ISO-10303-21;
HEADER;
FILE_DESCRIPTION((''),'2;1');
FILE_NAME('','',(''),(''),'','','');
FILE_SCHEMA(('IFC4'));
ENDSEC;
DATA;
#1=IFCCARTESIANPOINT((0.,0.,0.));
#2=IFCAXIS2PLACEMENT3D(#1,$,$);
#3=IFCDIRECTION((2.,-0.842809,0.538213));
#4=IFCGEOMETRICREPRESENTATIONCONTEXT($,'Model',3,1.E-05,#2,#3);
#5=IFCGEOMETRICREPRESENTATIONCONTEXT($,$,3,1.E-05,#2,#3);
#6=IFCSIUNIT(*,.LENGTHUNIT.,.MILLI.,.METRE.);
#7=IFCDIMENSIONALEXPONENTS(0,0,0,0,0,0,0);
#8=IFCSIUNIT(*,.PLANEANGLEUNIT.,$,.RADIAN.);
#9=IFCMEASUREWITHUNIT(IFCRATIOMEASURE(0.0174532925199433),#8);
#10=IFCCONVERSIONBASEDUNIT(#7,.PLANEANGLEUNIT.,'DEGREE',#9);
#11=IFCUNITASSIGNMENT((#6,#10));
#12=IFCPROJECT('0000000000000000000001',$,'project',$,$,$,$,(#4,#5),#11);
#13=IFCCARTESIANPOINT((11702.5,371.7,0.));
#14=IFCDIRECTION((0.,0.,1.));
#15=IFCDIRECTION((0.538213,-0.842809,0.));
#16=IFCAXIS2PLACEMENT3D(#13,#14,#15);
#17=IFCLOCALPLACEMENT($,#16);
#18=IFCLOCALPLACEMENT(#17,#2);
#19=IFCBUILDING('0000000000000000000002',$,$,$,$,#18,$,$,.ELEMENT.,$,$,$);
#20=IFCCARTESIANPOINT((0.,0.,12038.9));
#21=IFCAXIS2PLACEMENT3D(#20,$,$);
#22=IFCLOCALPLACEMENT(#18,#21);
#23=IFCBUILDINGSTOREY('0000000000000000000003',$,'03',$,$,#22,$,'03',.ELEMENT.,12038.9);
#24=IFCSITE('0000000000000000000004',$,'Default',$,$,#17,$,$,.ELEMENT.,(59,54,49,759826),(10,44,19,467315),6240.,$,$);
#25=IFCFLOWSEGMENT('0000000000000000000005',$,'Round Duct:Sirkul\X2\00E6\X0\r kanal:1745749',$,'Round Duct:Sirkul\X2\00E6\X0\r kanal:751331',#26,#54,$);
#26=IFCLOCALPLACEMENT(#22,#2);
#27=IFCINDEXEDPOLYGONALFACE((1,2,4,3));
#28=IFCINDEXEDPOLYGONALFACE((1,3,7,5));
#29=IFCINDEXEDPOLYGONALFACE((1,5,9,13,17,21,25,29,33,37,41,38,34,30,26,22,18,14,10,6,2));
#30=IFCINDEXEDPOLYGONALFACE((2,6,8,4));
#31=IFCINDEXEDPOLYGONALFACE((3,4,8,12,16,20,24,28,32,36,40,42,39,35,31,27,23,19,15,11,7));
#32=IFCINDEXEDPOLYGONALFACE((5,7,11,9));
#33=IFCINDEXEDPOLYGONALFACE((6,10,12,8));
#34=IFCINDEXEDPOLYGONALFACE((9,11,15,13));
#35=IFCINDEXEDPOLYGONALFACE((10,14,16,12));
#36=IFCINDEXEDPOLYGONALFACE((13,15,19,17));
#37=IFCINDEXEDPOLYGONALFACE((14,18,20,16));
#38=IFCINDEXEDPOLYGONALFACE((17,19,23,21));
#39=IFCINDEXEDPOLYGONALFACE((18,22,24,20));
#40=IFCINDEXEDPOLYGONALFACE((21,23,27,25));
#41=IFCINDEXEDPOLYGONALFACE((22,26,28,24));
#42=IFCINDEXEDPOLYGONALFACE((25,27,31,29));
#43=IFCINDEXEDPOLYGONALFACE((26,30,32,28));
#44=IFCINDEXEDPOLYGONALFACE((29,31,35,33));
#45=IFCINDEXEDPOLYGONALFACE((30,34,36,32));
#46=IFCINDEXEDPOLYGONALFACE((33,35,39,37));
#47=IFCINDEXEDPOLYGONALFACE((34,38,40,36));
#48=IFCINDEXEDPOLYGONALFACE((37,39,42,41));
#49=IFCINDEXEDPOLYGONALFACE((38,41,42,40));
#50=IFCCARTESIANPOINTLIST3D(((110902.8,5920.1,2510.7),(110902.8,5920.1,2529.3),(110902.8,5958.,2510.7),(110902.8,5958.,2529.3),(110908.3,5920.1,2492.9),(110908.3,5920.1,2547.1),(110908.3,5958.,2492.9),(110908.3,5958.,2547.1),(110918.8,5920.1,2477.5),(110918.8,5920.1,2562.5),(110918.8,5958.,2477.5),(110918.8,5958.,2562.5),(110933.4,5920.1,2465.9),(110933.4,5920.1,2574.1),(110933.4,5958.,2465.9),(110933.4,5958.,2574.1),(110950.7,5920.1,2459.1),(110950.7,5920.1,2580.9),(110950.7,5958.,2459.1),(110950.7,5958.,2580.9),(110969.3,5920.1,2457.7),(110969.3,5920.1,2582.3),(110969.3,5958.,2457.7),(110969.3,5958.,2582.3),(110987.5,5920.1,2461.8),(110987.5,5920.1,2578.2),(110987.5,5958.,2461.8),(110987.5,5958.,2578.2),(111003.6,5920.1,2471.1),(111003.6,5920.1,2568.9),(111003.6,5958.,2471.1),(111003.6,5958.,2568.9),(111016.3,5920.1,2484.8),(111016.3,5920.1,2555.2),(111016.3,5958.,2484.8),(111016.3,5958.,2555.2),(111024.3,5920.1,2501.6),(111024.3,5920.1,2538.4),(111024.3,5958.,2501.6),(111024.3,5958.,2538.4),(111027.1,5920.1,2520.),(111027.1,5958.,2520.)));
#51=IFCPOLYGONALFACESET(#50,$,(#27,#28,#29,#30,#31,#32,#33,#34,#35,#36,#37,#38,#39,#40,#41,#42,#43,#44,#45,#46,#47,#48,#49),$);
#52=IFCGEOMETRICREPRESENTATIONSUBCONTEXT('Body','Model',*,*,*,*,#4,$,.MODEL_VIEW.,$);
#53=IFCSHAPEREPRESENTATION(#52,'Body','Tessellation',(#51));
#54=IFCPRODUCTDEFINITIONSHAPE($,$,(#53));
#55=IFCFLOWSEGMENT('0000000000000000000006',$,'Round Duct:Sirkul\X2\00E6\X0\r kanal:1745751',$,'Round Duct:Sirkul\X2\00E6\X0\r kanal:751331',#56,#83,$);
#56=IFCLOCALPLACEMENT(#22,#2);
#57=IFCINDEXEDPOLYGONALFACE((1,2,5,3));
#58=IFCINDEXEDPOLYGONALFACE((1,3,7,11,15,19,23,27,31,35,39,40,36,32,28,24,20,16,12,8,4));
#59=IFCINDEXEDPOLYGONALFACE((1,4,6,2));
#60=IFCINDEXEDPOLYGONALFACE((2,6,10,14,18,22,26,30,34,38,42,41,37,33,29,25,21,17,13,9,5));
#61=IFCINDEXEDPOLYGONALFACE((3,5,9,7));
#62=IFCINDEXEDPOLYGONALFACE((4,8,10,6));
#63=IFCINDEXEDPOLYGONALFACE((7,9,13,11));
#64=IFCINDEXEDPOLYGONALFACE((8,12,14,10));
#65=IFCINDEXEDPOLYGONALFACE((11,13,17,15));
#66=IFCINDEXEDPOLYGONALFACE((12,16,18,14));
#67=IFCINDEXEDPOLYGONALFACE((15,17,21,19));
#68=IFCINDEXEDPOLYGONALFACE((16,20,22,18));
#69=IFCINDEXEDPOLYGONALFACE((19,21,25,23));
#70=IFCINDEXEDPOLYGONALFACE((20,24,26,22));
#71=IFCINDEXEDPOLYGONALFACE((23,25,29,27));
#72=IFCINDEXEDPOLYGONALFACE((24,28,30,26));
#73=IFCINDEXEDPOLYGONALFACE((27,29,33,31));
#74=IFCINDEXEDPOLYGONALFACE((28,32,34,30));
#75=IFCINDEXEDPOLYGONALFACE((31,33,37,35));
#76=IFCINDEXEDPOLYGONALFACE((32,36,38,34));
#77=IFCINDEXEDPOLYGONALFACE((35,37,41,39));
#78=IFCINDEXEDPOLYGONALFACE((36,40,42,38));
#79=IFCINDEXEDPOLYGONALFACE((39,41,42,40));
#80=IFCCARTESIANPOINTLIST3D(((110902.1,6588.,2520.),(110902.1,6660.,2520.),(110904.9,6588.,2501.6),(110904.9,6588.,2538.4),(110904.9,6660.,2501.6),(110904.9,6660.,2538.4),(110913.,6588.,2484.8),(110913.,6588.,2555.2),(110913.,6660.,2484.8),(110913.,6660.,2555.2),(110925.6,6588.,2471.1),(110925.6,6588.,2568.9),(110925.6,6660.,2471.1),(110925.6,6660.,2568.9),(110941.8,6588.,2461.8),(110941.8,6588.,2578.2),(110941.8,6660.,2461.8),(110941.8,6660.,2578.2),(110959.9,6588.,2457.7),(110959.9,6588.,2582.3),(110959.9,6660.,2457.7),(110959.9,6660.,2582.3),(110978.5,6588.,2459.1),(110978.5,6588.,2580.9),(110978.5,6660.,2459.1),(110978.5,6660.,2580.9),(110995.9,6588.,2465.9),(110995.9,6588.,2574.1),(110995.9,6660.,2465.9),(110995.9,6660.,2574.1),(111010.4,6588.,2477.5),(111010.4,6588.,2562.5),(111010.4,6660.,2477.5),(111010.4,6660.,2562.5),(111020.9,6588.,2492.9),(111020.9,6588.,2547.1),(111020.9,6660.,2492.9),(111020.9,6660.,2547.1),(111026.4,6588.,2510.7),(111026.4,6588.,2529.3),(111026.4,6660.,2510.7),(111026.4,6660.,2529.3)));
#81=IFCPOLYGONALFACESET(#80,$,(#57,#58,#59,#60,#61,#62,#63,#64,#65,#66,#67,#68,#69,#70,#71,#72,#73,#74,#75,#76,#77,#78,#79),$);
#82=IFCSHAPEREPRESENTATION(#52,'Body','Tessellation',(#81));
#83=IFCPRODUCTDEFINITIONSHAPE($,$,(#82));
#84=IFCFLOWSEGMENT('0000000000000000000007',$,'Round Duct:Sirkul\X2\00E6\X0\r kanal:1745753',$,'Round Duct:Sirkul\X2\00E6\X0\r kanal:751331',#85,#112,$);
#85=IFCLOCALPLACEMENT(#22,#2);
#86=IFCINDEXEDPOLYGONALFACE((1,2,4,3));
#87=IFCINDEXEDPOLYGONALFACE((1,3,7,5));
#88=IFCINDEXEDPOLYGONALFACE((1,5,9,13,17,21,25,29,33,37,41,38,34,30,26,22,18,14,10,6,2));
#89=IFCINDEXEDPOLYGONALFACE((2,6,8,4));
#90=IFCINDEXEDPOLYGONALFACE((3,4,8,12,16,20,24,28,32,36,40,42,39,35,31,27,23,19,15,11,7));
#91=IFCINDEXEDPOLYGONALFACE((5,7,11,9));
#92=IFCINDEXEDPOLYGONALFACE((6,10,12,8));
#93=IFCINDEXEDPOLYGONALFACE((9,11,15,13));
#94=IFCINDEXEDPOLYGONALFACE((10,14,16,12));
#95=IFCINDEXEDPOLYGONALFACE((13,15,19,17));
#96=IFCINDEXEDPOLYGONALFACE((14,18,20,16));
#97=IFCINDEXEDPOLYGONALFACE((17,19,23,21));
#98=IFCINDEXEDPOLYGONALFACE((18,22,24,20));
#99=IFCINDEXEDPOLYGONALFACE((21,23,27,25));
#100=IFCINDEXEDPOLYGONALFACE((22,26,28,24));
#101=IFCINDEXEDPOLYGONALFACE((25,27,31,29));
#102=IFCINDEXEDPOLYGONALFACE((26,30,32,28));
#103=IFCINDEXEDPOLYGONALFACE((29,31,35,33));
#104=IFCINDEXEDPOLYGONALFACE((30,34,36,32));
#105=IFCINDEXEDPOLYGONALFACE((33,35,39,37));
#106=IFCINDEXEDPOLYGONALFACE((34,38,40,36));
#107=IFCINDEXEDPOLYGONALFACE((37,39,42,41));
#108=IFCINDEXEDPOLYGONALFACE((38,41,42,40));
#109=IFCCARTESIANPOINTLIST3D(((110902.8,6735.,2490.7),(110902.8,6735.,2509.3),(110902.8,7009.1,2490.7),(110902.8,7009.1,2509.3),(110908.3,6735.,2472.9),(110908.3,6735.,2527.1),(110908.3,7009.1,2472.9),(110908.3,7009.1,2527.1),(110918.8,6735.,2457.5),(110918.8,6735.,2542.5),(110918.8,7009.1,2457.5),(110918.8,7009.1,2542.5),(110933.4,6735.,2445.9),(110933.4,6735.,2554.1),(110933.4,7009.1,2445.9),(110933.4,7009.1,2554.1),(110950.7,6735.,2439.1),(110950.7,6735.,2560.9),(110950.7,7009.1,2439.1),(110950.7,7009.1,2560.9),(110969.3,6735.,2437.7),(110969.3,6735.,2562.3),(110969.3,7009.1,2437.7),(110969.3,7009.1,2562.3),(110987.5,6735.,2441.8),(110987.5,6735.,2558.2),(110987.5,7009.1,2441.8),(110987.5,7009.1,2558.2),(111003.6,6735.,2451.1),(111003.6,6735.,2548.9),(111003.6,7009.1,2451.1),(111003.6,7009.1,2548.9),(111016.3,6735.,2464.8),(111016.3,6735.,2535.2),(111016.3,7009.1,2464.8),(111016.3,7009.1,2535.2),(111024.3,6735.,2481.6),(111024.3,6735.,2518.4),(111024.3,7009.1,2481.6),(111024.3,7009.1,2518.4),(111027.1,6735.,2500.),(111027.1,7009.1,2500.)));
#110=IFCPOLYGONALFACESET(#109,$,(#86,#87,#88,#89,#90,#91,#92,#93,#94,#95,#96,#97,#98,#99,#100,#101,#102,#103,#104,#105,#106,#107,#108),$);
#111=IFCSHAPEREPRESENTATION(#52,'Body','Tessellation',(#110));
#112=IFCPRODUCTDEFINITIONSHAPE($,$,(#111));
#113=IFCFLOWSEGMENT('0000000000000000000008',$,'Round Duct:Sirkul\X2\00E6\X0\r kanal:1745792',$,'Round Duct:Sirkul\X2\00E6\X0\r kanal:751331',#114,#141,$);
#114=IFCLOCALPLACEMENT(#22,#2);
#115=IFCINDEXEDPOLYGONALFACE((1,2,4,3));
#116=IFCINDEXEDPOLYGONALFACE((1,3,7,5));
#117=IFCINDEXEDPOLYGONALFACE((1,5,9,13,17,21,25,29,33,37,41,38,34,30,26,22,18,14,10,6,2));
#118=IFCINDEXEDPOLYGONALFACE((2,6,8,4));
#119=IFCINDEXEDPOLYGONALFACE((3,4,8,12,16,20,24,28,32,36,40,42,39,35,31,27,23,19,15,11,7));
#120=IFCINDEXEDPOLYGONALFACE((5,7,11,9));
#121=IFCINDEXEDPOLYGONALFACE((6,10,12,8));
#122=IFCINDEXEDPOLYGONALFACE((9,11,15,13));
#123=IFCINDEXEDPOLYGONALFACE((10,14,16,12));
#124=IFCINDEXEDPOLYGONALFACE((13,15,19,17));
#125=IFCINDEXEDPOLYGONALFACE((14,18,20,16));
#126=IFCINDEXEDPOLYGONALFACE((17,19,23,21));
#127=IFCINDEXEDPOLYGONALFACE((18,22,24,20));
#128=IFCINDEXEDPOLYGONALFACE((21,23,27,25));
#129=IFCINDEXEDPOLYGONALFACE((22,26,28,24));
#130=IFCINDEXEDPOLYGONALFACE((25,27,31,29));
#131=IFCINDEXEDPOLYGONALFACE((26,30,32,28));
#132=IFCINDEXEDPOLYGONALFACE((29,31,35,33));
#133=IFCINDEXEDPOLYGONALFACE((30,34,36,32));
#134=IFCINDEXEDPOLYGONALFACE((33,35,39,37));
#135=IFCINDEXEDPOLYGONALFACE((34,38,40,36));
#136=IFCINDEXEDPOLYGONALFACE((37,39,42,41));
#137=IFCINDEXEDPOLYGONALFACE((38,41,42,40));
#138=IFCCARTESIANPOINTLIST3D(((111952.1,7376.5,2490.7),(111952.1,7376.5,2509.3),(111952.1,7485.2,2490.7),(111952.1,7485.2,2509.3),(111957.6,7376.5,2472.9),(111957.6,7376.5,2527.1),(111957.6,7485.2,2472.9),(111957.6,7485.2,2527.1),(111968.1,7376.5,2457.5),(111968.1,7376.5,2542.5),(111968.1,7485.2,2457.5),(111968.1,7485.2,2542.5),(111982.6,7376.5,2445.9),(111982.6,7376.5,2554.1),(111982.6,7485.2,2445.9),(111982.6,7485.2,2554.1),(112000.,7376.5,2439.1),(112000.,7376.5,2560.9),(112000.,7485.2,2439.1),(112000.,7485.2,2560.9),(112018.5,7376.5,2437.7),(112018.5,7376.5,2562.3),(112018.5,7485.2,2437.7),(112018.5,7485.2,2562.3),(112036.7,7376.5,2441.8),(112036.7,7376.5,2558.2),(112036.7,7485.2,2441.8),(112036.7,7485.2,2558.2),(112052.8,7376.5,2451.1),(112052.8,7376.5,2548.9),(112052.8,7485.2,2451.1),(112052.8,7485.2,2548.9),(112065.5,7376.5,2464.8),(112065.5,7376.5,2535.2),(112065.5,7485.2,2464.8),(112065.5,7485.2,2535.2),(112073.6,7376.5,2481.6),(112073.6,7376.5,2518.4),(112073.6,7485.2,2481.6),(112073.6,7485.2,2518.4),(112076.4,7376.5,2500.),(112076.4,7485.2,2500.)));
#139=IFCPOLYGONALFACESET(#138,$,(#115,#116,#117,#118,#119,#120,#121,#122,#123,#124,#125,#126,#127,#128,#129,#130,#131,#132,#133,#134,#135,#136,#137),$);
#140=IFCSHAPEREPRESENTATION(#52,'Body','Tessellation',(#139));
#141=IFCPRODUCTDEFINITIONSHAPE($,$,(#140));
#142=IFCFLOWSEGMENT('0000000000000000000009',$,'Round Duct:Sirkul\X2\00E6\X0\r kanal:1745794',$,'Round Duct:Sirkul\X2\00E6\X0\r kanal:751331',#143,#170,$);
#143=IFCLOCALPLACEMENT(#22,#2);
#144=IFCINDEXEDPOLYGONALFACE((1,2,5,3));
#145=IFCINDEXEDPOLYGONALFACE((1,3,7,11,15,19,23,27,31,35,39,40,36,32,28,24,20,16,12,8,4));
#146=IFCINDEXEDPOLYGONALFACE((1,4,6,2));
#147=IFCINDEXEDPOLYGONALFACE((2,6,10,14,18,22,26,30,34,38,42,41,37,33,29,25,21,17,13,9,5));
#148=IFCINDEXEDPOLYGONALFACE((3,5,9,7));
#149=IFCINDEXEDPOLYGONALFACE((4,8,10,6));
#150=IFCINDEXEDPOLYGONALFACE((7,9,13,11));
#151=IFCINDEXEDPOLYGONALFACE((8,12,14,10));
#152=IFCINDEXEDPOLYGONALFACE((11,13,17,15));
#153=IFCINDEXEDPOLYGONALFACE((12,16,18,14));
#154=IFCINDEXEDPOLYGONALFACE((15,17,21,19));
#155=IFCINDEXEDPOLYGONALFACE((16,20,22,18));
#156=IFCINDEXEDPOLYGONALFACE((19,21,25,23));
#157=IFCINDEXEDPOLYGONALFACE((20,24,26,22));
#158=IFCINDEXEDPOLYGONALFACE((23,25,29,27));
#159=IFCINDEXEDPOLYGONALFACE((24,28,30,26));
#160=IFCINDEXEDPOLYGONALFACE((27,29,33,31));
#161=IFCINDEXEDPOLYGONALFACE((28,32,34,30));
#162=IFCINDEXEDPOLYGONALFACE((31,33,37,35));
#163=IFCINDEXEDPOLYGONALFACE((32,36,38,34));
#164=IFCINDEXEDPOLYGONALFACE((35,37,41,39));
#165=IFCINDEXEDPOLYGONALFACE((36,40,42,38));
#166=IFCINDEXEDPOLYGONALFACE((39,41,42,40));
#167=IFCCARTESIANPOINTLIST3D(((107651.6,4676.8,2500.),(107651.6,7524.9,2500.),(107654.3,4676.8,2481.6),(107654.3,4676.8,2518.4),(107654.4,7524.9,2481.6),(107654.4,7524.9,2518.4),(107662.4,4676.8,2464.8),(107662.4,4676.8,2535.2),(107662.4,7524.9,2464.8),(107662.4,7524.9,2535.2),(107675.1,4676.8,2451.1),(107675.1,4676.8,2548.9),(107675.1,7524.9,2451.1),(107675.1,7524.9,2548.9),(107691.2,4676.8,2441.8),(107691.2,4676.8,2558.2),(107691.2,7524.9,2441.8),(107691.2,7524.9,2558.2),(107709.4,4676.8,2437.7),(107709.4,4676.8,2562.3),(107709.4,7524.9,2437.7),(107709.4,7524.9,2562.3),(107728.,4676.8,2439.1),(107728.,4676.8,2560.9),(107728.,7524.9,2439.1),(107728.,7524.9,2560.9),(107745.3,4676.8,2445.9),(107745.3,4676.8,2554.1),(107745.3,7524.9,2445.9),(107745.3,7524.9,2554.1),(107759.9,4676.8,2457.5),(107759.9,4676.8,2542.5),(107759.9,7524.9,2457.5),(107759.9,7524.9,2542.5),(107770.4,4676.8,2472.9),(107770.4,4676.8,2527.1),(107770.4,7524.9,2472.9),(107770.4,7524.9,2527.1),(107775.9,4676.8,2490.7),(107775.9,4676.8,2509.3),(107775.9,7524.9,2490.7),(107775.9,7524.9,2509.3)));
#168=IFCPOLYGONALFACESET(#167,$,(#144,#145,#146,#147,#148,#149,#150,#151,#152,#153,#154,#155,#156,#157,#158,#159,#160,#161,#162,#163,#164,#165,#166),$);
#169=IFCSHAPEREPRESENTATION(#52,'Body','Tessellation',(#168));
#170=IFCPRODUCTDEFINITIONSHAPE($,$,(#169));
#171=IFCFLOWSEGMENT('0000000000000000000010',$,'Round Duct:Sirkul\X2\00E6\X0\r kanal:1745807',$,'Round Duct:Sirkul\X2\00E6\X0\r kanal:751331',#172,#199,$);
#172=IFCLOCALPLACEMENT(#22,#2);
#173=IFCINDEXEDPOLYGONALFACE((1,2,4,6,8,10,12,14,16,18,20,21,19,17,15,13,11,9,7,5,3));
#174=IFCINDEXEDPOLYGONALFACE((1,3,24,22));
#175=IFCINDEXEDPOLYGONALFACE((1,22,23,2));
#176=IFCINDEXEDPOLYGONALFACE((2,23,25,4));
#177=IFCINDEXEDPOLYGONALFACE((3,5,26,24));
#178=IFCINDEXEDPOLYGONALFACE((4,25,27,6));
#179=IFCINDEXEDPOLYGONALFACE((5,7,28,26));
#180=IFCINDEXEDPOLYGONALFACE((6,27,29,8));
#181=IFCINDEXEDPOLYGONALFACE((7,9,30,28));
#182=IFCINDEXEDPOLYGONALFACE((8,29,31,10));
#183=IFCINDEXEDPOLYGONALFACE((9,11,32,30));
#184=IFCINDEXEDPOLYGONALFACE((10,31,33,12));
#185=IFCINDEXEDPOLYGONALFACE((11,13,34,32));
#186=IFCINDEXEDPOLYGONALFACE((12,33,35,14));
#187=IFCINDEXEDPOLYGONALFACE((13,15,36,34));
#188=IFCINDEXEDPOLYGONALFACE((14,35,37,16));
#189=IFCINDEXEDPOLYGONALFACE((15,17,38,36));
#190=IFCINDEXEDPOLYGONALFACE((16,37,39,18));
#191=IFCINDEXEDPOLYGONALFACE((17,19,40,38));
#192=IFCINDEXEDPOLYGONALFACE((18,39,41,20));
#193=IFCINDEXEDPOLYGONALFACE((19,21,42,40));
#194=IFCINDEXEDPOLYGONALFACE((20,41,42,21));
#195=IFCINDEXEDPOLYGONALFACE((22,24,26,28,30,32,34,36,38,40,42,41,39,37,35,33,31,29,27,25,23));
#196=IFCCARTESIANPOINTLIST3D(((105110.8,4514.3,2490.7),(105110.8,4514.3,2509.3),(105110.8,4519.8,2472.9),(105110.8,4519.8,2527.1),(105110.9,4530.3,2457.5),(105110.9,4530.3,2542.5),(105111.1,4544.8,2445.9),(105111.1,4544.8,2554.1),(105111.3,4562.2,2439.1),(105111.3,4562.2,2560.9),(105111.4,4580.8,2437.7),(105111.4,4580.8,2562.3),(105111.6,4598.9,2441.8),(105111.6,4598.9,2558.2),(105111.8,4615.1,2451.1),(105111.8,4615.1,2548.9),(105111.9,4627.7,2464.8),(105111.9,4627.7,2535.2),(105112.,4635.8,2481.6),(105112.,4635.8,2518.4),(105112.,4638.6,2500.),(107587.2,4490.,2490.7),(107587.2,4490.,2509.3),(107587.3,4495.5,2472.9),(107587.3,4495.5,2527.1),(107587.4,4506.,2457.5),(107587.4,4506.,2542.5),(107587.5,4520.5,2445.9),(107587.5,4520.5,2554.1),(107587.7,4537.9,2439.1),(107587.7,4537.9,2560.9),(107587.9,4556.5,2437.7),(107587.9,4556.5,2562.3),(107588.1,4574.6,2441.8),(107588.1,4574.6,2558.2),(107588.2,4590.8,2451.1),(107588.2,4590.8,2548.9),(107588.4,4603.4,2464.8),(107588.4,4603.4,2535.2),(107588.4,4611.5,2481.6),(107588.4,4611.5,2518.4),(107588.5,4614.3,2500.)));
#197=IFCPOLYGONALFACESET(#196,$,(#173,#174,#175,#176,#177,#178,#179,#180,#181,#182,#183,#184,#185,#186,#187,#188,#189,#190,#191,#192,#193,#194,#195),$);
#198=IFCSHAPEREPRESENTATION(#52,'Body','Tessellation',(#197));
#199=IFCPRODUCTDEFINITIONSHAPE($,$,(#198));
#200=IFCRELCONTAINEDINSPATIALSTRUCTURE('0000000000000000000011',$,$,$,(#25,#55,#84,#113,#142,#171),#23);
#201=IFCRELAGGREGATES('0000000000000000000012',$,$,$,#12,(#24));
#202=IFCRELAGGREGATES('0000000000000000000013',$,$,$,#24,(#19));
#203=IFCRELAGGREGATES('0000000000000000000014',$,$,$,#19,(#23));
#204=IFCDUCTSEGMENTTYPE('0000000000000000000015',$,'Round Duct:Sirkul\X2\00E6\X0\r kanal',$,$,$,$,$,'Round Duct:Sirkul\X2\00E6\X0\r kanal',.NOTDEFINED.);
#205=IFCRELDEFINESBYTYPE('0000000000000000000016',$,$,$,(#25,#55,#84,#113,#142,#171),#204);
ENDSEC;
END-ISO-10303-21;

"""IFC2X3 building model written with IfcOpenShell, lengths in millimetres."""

from ifc_helpers import new_model, entity, si_unit, converted_unit, direction, frame, frame_2d, origin, origin_2d_with_axis, place, context, subcontext, project, spatial, circle, extrude, type_object, element, save


model = new_model("IFC2X3")

# Units and contexts
model_context = context("Model", 3, precision=1e-05, world=origin(), true_north=direction((2.0, -0.842809, 0.538213)))
context_of_model = context(None, 3, precision=1e-05, world=origin(), true_north=direction((2.0, -0.842809, 0.538213)))
body_context = subcontext(model_context, "Body", "Model", "MODEL_VIEW")
ifc_project = project(units=[si_unit("LENGTHUNIT", "METRE", prefix="MILLI"), converted_unit("PLANEANGLEUNIT", "DEGREE", entity("IfcRatioMeasure", 0.0174532925199433), si_unit("PLANEANGLEUNIT", "RADIAN"), dimensions=[0, 0, 0, 0, 0, 0, 0])], contexts=[model_context, context_of_model])

# Site, building, storey
site_placement = place(None, frame((11702.5, 371.7, 0.0), z_axis=(0.0, 0.0, 1.0), x_axis=(0.538213, -0.842809, 0.0)))
site = spatial("IfcSite", under=ifc_project, at=site_placement, Name="Default", CompositionType="ELEMENT", RefLatitude=(59, 54, 49, 759826), RefLongitude=(10, 44, 19, 467315), RefElevation=6240.0)
building_placement = place(site_placement, origin())
building = spatial("IfcBuilding", under=site, at=building_placement, CompositionType="ELEMENT")
storey_placement = place(building_placement, frame((0.0, 0.0, 12038.9)))
storey = spatial("IfcBuildingStorey", under=building, at=storey_placement, Name="03", LongName="03", CompositionType="ELEMENT", Elevation=12038.9)

# Flow segments
duct_segment_type = type_object("IfcDuctSegmentType", Name="Round Duct:Sirkulær kanal", ElementType="Round Duct:Sirkulær kanal", PredefinedType="NOTDEFINED")
flow_segment_1_placement = place(storey_placement, origin())
element("IfcFlowSegment", 1, at=flow_segment_1_placement, inside=storey, type_object=duct_segment_type, Name="Round Duct:Sirkulær kanal:1745749", ObjectType="Round Duct:Sirkulær kanal:751331", context=body_context, shape_type="SweptSolid", body=[
    extrude(circle(Radius=62.5, at=frame_2d((0.0, 0.0), x_axis=(1.0, 0.0))), frame((110964.6, 5920.1, 2520.0), z_axis=(0.0, 1.0, 0.0), x_axis=(1.0, 0.0, 0.0)), (0.0, 0.0, 1.0), 37.9),
])
flow_segment_2_placement = place(storey_placement, origin())
element("IfcFlowSegment", 2, at=flow_segment_2_placement, inside=storey, type_object=duct_segment_type, Name="Round Duct:Sirkulær kanal:1745751", ObjectType="Round Duct:Sirkulær kanal:751331", context=body_context, shape_type="SweptSolid", body=[
    extrude(circle(Radius=62.5, at=frame_2d((0.0, 0.0), x_axis=(1.0, 0.0))), frame((110964.6, 6588.0, 2520.0), z_axis=(0.0, 1.0, 0.0), x_axis=(-1.0, 0.0, 0.0)), (0.0, 0.0, 1.0), 72.0),
])
flow_segment_3_placement = place(storey_placement, origin())
element("IfcFlowSegment", 3, at=flow_segment_3_placement, inside=storey, type_object=duct_segment_type, Name="Round Duct:Sirkulær kanal:1745753", ObjectType="Round Duct:Sirkulær kanal:751331", context=body_context, shape_type="SweptSolid", body=[
    extrude(circle(Radius=62.5, at=origin_2d_with_axis()), frame((110964.6, 6735.0, 2500.0), z_axis=(0.0, 1.0, 0.0), x_axis=(1.0, 0.0, 0.0)), (0.0, 0.0, 1.0), 274.1),
])
flow_segment_4_placement = place(storey_placement, origin())
element("IfcFlowSegment", 4, at=flow_segment_4_placement, inside=storey, type_object=duct_segment_type, Name="Round Duct:Sirkulær kanal:1745792", ObjectType="Round Duct:Sirkulær kanal:751331", context=body_context, shape_type="SweptSolid", body=[
    extrude(circle(Radius=62.5, at=frame_2d((0.0, 0.0), x_axis=(1.0, 0.0))), frame((112013.9, 7376.5, 2500.0), z_axis=(0.000003, 1.0, 0.0), x_axis=(1.0, -0.000003, 0.0)), (0.0, 0.0, 1.0), 108.7),
])
flow_segment_5_placement = place(storey_placement, origin())
element("IfcFlowSegment", 5, at=flow_segment_5_placement, inside=storey, type_object=duct_segment_type, Name="Round Duct:Sirkulær kanal:1745794", ObjectType="Round Duct:Sirkulær kanal:751331", context=body_context, shape_type="SweptSolid", body=[
    extrude(circle(Radius=62.5, at=origin_2d_with_axis()), frame((107714.1, 4676.8, 2500.0), z_axis=(0.000002, 1.0, 0.0), x_axis=(-1.0, 0.000002, 0.0)), (0.0, 0.0, 1.0), 2848.1),
])
flow_segment_6_placement = place(storey_placement, origin())
element("IfcFlowSegment", 6, at=flow_segment_6_placement, inside=storey, type_object=duct_segment_type, Name="Round Duct:Sirkulær kanal:1745807", ObjectType="Round Duct:Sirkulær kanal:751331", context=body_context, shape_type="SweptSolid", body=[
    extrude(circle(Radius=62.5, at=frame_2d((0.0, 0.0), x_axis=(1.0, 0.0))), frame((107587.8, 4551.8, 2500.0), z_axis=(-0.999952, 0.00981, 0.0), x_axis=(0.00981, 0.999952, 0.0)), (0.0, 0.0, 1.0), 2476.6),
])

save(model, "model.ifc")
